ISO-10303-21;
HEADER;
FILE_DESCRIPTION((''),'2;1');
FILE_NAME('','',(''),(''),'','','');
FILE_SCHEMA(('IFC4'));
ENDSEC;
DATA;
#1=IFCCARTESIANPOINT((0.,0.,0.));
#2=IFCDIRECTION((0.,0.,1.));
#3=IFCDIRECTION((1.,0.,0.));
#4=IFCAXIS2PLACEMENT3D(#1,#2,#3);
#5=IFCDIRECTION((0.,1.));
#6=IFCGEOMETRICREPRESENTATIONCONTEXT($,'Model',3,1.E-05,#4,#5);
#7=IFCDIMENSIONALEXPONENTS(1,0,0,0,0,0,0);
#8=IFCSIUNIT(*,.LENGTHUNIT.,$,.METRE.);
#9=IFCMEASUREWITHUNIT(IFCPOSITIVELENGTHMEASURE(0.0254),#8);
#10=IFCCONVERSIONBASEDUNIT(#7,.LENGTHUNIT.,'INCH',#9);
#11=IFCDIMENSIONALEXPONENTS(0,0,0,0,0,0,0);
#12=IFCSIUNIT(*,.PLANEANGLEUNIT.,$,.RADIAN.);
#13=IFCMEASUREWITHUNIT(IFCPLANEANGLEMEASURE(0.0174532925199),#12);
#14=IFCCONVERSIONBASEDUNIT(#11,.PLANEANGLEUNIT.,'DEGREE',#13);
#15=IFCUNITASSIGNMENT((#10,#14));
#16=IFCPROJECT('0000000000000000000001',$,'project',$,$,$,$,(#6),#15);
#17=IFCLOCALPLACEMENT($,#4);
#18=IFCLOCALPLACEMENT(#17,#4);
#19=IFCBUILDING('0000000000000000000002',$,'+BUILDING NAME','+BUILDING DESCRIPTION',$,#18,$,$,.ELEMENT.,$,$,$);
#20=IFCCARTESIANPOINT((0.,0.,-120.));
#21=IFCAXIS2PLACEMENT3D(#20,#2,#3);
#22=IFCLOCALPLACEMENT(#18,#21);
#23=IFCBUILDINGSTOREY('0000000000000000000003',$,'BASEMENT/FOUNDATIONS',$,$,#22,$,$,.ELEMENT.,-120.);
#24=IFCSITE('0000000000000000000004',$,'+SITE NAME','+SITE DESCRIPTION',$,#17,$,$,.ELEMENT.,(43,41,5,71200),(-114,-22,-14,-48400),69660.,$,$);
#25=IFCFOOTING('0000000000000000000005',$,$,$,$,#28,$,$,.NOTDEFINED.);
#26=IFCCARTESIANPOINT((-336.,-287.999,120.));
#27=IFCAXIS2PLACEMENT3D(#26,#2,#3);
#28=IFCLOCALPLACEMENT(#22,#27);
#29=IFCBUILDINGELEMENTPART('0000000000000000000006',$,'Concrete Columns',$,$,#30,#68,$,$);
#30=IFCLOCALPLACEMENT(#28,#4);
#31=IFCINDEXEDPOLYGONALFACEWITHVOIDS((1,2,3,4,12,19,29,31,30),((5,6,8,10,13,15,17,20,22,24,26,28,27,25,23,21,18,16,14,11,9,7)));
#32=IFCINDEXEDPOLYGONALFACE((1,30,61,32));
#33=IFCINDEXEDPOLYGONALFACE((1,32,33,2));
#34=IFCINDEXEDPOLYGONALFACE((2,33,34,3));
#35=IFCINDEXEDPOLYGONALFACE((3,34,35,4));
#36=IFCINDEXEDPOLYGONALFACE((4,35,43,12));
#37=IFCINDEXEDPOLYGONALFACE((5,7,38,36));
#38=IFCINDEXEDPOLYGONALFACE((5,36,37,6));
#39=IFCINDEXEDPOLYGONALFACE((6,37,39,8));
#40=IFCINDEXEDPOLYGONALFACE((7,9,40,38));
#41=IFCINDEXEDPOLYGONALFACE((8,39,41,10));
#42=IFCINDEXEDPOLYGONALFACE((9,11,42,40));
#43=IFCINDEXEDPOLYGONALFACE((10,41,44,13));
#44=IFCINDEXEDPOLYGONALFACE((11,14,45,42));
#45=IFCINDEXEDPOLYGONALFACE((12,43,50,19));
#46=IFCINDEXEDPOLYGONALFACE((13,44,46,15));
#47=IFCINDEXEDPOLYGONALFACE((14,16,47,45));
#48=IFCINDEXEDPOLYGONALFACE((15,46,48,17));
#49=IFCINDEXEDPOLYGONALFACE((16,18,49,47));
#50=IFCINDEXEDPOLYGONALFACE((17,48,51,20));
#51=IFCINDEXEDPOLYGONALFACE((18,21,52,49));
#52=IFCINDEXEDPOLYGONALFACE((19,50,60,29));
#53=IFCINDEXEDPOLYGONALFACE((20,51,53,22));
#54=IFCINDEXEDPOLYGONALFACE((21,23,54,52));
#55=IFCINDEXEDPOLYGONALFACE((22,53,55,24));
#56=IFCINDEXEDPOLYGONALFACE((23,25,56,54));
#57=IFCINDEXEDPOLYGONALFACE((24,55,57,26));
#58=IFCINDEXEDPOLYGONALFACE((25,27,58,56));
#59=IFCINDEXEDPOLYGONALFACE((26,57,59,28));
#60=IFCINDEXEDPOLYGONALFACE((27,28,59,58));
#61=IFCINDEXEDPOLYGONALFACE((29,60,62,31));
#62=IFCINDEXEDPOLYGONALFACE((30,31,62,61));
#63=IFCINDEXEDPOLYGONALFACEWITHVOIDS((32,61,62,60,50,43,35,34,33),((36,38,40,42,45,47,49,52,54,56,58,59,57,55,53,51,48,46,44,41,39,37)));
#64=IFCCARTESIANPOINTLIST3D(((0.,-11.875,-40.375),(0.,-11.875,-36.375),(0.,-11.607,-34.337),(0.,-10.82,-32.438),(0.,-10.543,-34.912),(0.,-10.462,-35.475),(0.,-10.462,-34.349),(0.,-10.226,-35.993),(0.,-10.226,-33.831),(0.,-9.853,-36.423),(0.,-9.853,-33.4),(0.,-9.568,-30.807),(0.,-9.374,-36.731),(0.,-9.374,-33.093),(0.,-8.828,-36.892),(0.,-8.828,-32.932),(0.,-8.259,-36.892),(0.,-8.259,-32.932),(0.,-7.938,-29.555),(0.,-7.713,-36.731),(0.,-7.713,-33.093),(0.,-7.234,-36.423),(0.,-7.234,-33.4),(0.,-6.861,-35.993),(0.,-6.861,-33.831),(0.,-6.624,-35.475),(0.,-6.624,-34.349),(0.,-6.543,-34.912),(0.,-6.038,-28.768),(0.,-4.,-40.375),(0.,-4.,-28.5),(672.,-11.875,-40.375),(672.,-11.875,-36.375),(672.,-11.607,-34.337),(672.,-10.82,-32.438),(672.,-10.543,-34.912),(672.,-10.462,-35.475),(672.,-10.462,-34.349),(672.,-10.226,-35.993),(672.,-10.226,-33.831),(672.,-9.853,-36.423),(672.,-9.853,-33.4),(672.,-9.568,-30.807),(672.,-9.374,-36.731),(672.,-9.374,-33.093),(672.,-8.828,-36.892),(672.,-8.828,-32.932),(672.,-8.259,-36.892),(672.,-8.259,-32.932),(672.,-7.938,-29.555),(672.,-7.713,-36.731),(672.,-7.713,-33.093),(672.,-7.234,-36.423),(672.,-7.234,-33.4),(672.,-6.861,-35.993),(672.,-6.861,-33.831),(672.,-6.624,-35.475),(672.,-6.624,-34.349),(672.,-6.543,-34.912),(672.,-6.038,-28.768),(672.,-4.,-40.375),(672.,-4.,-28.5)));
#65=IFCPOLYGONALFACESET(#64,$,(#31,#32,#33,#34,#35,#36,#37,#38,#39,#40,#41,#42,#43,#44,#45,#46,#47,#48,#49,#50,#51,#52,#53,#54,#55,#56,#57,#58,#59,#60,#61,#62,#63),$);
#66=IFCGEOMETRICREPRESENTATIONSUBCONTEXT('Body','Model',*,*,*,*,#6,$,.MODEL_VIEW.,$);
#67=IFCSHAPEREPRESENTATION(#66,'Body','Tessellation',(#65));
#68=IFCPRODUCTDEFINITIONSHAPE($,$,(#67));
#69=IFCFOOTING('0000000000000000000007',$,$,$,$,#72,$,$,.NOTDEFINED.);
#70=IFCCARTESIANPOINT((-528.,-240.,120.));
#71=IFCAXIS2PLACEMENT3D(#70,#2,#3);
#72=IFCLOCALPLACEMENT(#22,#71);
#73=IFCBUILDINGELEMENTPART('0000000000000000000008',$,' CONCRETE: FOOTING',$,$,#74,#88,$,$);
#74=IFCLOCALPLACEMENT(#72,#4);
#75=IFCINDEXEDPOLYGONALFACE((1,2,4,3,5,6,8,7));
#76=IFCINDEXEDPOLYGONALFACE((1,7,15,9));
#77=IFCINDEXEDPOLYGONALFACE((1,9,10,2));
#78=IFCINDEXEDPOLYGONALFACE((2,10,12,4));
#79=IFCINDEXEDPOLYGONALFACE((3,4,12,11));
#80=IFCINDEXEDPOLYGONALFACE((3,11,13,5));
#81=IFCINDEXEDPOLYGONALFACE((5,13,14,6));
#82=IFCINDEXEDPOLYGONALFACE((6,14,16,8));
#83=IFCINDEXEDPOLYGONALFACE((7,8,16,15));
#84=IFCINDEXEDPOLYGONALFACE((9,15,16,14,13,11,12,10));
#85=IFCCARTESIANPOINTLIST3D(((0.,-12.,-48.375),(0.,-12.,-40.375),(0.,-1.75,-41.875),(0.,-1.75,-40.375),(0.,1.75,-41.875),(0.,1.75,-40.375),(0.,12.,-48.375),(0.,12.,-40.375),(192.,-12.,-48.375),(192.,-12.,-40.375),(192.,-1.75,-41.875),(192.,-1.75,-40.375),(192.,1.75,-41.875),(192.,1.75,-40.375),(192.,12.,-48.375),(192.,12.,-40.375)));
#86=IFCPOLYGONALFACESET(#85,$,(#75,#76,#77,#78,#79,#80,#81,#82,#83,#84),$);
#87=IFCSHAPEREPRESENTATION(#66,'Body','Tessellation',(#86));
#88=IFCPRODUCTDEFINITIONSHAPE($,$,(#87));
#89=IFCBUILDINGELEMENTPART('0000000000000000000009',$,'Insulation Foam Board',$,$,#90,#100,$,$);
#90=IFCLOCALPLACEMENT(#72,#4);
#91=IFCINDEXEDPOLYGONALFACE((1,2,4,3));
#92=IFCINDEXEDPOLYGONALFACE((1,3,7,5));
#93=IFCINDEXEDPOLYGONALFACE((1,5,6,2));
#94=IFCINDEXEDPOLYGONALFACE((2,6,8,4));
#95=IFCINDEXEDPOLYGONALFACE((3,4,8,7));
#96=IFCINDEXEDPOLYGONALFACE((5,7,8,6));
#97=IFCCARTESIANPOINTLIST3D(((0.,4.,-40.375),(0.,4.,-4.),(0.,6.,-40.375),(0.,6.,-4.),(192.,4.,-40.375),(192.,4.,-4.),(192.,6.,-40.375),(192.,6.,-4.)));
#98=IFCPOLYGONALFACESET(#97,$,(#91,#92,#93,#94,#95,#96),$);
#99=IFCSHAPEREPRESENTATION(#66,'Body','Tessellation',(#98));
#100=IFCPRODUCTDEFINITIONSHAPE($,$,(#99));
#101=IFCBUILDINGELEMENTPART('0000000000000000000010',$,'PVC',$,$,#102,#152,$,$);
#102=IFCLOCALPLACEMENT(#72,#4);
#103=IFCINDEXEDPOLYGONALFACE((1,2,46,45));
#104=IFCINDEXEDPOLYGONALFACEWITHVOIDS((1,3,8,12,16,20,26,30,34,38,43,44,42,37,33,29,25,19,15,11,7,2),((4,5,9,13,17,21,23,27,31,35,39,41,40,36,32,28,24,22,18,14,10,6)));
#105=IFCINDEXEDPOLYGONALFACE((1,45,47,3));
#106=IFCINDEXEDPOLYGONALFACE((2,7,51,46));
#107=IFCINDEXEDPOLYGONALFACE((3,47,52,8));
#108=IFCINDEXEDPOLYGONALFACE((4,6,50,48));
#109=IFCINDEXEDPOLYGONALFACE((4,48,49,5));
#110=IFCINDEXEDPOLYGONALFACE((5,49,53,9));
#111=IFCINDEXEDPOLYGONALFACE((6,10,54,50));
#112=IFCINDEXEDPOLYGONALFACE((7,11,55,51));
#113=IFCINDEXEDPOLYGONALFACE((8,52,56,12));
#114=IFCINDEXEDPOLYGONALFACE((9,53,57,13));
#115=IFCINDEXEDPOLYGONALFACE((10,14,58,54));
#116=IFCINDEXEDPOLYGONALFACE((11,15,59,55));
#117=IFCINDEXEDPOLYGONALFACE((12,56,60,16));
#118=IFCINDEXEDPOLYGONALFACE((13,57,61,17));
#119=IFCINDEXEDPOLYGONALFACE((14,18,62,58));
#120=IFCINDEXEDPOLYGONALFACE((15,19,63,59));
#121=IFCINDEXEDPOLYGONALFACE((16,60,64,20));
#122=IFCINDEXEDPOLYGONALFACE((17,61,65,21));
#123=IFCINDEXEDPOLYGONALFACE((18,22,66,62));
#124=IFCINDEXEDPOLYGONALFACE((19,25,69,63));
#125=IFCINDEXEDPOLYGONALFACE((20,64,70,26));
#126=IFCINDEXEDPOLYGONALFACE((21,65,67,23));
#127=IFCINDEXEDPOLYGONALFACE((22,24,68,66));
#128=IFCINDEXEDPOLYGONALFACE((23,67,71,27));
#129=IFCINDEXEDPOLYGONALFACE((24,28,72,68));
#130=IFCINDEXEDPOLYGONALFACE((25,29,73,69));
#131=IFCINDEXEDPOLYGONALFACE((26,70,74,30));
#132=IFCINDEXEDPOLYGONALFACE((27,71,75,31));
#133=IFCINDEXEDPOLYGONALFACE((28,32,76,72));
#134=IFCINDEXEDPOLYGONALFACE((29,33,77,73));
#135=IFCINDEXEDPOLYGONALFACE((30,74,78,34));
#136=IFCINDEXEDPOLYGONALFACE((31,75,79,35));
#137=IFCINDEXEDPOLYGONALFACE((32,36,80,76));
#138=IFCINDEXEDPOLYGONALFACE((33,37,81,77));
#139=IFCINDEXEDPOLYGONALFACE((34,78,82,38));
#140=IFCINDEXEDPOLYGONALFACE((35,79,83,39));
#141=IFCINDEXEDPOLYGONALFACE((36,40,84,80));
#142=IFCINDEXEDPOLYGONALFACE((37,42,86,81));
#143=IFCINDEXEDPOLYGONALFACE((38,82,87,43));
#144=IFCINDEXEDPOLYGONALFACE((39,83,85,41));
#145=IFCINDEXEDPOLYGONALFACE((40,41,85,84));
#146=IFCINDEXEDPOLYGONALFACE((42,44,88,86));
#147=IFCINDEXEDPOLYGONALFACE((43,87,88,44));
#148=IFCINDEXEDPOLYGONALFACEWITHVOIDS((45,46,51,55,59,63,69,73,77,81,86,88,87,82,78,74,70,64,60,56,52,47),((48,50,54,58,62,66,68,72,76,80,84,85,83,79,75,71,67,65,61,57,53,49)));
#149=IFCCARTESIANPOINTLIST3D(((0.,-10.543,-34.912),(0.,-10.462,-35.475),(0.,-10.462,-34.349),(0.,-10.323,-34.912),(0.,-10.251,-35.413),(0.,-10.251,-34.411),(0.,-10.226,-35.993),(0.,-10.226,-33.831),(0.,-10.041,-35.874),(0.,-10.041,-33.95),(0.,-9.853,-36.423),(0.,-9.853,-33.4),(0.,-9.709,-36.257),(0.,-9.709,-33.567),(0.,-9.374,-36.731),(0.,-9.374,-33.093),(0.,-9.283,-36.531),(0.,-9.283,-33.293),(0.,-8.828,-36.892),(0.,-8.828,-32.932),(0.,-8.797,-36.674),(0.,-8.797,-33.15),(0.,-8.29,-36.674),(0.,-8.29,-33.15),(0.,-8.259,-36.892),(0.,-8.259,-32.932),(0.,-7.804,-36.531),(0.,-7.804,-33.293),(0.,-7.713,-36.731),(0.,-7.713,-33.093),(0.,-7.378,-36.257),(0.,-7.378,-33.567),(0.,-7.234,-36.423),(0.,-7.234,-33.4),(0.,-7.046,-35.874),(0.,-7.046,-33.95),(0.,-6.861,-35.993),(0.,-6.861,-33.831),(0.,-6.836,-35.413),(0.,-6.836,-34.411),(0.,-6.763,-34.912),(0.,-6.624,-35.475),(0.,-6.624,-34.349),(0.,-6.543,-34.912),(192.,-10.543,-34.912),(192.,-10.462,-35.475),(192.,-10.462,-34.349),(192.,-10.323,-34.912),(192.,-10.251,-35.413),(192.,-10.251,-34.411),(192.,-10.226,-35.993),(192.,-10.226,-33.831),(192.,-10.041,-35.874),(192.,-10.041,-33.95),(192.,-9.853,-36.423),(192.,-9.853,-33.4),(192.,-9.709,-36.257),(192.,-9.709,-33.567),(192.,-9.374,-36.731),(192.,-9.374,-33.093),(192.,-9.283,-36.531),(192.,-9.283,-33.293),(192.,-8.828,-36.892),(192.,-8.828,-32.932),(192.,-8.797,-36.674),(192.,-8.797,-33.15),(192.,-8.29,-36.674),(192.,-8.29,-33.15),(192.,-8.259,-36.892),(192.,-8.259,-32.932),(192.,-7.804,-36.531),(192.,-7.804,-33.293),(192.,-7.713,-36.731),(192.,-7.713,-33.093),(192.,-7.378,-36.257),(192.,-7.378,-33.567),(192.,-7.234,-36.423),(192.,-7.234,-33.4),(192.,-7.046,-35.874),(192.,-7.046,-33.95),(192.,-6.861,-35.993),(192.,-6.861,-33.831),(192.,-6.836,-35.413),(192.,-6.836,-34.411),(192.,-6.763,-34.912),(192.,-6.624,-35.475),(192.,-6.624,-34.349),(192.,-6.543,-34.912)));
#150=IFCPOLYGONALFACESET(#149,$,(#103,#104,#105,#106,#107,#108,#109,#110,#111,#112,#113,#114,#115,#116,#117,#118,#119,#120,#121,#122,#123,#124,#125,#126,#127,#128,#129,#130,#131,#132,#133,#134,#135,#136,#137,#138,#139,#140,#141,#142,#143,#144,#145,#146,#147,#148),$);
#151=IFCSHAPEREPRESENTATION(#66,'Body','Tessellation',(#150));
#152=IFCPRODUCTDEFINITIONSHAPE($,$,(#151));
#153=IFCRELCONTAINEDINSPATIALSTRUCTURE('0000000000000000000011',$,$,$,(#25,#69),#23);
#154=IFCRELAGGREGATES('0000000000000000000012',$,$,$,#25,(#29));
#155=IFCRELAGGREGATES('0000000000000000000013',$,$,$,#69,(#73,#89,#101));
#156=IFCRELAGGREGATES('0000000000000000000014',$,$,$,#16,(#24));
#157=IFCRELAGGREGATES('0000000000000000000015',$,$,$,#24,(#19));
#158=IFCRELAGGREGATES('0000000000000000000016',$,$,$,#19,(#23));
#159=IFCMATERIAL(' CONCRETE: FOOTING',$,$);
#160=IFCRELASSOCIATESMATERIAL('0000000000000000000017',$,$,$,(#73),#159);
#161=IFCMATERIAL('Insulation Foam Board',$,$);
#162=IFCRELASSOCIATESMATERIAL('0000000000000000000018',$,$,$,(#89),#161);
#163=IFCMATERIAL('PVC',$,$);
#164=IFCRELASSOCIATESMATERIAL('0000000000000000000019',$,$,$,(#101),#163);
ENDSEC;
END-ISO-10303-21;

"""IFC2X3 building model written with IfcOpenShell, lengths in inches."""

from ifc_helpers import new_model, entity, si_unit, converted_unit, point, direction, frame, frame_2d, origin_with_axes, place, context, subcontext, project, spatial, polyline, circle_curve, parameter, trimmed, segment, composite_curve, outline, extrude, material, element, aggregate, save


model = new_model("IFC2X3")

# Units and contexts
model_context = context("Model", 3, precision=1e-05, world=origin_with_axes(), true_north=direction((0.0, 1.0)))
body_context = subcontext(model_context, "Body", "Model", "MODEL_VIEW")
ifc_project = project(units=[converted_unit("LENGTHUNIT", "INCH", entity("IfcPositiveLengthMeasure", 0.0254), si_unit("LENGTHUNIT", "METRE"), dimensions=[1, 0, 0, 0, 0, 0, 0]), converted_unit("PLANEANGLEUNIT", "DEGREE", entity("IfcPlaneAngleMeasure", 0.0174532925199), si_unit("PLANEANGLEUNIT", "RADIAN"), dimensions=[0, 0, 0, 0, 0, 0, 0])], contexts=[model_context])

# Site, building, storey
site_placement = place(None, origin_with_axes())
site = spatial("IfcSite", under=ifc_project, at=site_placement, Name="+SITE NAME", Description="+SITE DESCRIPTION", CompositionType="ELEMENT", RefLatitude=(43, 41, 5, 71200), RefLongitude=(-114, -22, -14, -48400), RefElevation=69660.0)
building_placement = place(site_placement, origin_with_axes())
building = spatial("IfcBuilding", under=site, at=building_placement, Name="+BUILDING NAME", Description="+BUILDING DESCRIPTION", CompositionType="ELEMENT")
storey_placement = place(building_placement, frame((0.0, 0.0, -120.0), z_axis=(0.0, 0.0, 1.0), x_axis=(1.0, 0.0, 0.0)))
storey = spatial("IfcBuildingStorey", under=building, at=storey_placement, Name="BASEMENT/FOUNDATIONS", CompositionType="ELEMENT", Elevation=-120.0)

# Footings, building element parts
ifc_material_1 = material(Name=" CONCRETE: FOOTING")
ifc_material_2 = material(Name="Insulation Foam Board")
ifc_material_3 = material(Name="PVC")
footing_1_placement = place(storey_placement, frame((-336.0, -287.999, 120.0), z_axis=(0.0, 0.0, 1.0), x_axis=(1.0, 0.0, 0.0)))
footing_1 = element("IfcFooting", 1, at=footing_1_placement, inside=storey, PredefinedType="NOTDEFINED")
building_element_part_1_placement = place(footing_1_placement, origin_with_axes())
building_element_part_1 = element("IfcBuildingElementPart", 2, at=building_element_part_1_placement, Name="Concrete Columns", context=body_context, shape_type="SweptSolid", body=[
    extrude(outline(composite_curve([segment(trimmed(circle_curve(frame_2d((4.0, -36.375), x_axis=(1.0, 0.0)), 7.875), [point((11.875, -36.375)), parameter(0.0)], [point((4.0, -28.5)), parameter(90.0)], True, "CARTESIAN"), True, "CONTINUOUS"), segment(polyline([(4.0, -28.5), (4.0, -40.375), (11.875, -40.375), (11.875, -36.375)]), True, "CONTINUOUS")], self_intersect=False), holes=[composite_curve([segment(trimmed(circle_curve(frame_2d((8.543, -34.912), x_axis=(-1.0, 0.0)), 2.0), [point((10.543, -34.912)), parameter(180.0)], [point((6.543, -34.912)), parameter(0.0)], False, "CARTESIAN"), True, "CONTINUOUS"), segment(trimmed(circle_curve(frame_2d((8.543, -34.912), x_axis=(1.0, 0.0)), 2.0), [point((6.543, -34.912)), parameter(180.0)], [point((10.543, -34.912)), parameter(0.0)], False, "CARTESIAN"), True, "CONTINUOUS")], self_intersect=False)]), frame((0.0, 0.0, 0.0), z_axis=(-1.0, 0.0, 0.0), x_axis=(0.0, -1.0, 0.0)), (0.0, 0.0, -1.0), 672.0),
])
aggregate(footing_1, [building_element_part_1])
footing_2_placement = place(storey_placement, frame((-528.0, -240.0, 120.0), z_axis=(0.0, 0.0, 1.0), x_axis=(1.0, 0.0, 0.0)))
footing_2 = element("IfcFooting", 3, at=footing_2_placement, inside=storey, PredefinedType="NOTDEFINED")
building_element_part_2_placement = place(footing_2_placement, origin_with_axes())
building_element_part_2 = element("IfcBuildingElementPart", 4, at=building_element_part_2_placement, material=ifc_material_1, Name=" CONCRETE: FOOTING", context=body_context, shape_type="SweptSolid", body=[
    extrude(outline(polyline([(-12.0, -48.375), (12.0, -48.375), (12.0, -40.375), (1.75, -40.375), (1.75, -41.875), (-1.75, -41.875), (-1.75, -40.375), (-12.0, -40.375), (-12.0, -48.375)])), frame((0.0, 0.0, 0.0), z_axis=(-1.0, 0.0, 0.0), x_axis=(0.0, -1.0, 0.0)), (0.0, 0.0, -1.0), 192.0),
])
building_element_part_3_placement = place(footing_2_placement, origin_with_axes())
building_element_part_3 = element("IfcBuildingElementPart", 5, at=building_element_part_3_placement, material=ifc_material_2, Name="Insulation Foam Board", context=body_context, shape_type="SweptSolid", body=[
    extrude(outline(polyline([(-4.0, -4.0), (-6.0, -4.0), (-6.0, -40.375), (-4.0, -40.375), (-4.0, -4.0)])), frame((0.0, 0.0, 0.0), z_axis=(-1.0, 0.0, 0.0), x_axis=(0.0, -1.0, 0.0)), (0.0, 0.0, -1.0), 192.0),
])
building_element_part_4_placement = place(footing_2_placement, origin_with_axes())
building_element_part_4 = element("IfcBuildingElementPart", 6, at=building_element_part_4_placement, material=ifc_material_3, Name="PVC", context=body_context, shape_type="SweptSolid", body=[
    extrude(outline(composite_curve([segment(trimmed(circle_curve(frame_2d((8.543, -34.912), x_axis=(1.0, 0.0)), 2.0), [point((10.543, -34.912)), parameter(0.0)], [point((6.543, -34.912)), parameter(180.0)], True, "CARTESIAN"), True, "CONTINUOUS"), segment(trimmed(circle_curve(frame_2d((8.543, -34.912), x_axis=(-1.0, 0.0)), 2.0), [point((6.543, -34.912)), parameter(0.0)], [point((10.543, -34.912)), parameter(180.0)], True, "CARTESIAN"), True, "CONTINUOUS")], self_intersect=False), holes=[composite_curve([segment(trimmed(circle_curve(frame_2d((8.543, -34.912), x_axis=(-1.0, 0.0)), 1.78), [point((10.323, -34.912)), parameter(180.0)], [point((6.763, -34.912)), parameter(0.0)], False, "CARTESIAN"), True, "CONTINUOUS"), segment(trimmed(circle_curve(frame_2d((8.543, -34.912), x_axis=(1.0, 0.0)), 1.78), [point((6.763, -34.912)), parameter(180.0)], [point((10.323, -34.912)), parameter(0.0)], False, "CARTESIAN"), True, "CONTINUOUS")], self_intersect=False)]), frame((0.0, 0.0, 0.0), z_axis=(-1.0, 0.0, 0.0), x_axis=(0.0, -1.0, 0.0)), (0.0, 0.0, -1.0), 192.0),
])
aggregate(footing_2, [building_element_part_2, building_element_part_3, building_element_part_4])

save(model, "model.ifc")
